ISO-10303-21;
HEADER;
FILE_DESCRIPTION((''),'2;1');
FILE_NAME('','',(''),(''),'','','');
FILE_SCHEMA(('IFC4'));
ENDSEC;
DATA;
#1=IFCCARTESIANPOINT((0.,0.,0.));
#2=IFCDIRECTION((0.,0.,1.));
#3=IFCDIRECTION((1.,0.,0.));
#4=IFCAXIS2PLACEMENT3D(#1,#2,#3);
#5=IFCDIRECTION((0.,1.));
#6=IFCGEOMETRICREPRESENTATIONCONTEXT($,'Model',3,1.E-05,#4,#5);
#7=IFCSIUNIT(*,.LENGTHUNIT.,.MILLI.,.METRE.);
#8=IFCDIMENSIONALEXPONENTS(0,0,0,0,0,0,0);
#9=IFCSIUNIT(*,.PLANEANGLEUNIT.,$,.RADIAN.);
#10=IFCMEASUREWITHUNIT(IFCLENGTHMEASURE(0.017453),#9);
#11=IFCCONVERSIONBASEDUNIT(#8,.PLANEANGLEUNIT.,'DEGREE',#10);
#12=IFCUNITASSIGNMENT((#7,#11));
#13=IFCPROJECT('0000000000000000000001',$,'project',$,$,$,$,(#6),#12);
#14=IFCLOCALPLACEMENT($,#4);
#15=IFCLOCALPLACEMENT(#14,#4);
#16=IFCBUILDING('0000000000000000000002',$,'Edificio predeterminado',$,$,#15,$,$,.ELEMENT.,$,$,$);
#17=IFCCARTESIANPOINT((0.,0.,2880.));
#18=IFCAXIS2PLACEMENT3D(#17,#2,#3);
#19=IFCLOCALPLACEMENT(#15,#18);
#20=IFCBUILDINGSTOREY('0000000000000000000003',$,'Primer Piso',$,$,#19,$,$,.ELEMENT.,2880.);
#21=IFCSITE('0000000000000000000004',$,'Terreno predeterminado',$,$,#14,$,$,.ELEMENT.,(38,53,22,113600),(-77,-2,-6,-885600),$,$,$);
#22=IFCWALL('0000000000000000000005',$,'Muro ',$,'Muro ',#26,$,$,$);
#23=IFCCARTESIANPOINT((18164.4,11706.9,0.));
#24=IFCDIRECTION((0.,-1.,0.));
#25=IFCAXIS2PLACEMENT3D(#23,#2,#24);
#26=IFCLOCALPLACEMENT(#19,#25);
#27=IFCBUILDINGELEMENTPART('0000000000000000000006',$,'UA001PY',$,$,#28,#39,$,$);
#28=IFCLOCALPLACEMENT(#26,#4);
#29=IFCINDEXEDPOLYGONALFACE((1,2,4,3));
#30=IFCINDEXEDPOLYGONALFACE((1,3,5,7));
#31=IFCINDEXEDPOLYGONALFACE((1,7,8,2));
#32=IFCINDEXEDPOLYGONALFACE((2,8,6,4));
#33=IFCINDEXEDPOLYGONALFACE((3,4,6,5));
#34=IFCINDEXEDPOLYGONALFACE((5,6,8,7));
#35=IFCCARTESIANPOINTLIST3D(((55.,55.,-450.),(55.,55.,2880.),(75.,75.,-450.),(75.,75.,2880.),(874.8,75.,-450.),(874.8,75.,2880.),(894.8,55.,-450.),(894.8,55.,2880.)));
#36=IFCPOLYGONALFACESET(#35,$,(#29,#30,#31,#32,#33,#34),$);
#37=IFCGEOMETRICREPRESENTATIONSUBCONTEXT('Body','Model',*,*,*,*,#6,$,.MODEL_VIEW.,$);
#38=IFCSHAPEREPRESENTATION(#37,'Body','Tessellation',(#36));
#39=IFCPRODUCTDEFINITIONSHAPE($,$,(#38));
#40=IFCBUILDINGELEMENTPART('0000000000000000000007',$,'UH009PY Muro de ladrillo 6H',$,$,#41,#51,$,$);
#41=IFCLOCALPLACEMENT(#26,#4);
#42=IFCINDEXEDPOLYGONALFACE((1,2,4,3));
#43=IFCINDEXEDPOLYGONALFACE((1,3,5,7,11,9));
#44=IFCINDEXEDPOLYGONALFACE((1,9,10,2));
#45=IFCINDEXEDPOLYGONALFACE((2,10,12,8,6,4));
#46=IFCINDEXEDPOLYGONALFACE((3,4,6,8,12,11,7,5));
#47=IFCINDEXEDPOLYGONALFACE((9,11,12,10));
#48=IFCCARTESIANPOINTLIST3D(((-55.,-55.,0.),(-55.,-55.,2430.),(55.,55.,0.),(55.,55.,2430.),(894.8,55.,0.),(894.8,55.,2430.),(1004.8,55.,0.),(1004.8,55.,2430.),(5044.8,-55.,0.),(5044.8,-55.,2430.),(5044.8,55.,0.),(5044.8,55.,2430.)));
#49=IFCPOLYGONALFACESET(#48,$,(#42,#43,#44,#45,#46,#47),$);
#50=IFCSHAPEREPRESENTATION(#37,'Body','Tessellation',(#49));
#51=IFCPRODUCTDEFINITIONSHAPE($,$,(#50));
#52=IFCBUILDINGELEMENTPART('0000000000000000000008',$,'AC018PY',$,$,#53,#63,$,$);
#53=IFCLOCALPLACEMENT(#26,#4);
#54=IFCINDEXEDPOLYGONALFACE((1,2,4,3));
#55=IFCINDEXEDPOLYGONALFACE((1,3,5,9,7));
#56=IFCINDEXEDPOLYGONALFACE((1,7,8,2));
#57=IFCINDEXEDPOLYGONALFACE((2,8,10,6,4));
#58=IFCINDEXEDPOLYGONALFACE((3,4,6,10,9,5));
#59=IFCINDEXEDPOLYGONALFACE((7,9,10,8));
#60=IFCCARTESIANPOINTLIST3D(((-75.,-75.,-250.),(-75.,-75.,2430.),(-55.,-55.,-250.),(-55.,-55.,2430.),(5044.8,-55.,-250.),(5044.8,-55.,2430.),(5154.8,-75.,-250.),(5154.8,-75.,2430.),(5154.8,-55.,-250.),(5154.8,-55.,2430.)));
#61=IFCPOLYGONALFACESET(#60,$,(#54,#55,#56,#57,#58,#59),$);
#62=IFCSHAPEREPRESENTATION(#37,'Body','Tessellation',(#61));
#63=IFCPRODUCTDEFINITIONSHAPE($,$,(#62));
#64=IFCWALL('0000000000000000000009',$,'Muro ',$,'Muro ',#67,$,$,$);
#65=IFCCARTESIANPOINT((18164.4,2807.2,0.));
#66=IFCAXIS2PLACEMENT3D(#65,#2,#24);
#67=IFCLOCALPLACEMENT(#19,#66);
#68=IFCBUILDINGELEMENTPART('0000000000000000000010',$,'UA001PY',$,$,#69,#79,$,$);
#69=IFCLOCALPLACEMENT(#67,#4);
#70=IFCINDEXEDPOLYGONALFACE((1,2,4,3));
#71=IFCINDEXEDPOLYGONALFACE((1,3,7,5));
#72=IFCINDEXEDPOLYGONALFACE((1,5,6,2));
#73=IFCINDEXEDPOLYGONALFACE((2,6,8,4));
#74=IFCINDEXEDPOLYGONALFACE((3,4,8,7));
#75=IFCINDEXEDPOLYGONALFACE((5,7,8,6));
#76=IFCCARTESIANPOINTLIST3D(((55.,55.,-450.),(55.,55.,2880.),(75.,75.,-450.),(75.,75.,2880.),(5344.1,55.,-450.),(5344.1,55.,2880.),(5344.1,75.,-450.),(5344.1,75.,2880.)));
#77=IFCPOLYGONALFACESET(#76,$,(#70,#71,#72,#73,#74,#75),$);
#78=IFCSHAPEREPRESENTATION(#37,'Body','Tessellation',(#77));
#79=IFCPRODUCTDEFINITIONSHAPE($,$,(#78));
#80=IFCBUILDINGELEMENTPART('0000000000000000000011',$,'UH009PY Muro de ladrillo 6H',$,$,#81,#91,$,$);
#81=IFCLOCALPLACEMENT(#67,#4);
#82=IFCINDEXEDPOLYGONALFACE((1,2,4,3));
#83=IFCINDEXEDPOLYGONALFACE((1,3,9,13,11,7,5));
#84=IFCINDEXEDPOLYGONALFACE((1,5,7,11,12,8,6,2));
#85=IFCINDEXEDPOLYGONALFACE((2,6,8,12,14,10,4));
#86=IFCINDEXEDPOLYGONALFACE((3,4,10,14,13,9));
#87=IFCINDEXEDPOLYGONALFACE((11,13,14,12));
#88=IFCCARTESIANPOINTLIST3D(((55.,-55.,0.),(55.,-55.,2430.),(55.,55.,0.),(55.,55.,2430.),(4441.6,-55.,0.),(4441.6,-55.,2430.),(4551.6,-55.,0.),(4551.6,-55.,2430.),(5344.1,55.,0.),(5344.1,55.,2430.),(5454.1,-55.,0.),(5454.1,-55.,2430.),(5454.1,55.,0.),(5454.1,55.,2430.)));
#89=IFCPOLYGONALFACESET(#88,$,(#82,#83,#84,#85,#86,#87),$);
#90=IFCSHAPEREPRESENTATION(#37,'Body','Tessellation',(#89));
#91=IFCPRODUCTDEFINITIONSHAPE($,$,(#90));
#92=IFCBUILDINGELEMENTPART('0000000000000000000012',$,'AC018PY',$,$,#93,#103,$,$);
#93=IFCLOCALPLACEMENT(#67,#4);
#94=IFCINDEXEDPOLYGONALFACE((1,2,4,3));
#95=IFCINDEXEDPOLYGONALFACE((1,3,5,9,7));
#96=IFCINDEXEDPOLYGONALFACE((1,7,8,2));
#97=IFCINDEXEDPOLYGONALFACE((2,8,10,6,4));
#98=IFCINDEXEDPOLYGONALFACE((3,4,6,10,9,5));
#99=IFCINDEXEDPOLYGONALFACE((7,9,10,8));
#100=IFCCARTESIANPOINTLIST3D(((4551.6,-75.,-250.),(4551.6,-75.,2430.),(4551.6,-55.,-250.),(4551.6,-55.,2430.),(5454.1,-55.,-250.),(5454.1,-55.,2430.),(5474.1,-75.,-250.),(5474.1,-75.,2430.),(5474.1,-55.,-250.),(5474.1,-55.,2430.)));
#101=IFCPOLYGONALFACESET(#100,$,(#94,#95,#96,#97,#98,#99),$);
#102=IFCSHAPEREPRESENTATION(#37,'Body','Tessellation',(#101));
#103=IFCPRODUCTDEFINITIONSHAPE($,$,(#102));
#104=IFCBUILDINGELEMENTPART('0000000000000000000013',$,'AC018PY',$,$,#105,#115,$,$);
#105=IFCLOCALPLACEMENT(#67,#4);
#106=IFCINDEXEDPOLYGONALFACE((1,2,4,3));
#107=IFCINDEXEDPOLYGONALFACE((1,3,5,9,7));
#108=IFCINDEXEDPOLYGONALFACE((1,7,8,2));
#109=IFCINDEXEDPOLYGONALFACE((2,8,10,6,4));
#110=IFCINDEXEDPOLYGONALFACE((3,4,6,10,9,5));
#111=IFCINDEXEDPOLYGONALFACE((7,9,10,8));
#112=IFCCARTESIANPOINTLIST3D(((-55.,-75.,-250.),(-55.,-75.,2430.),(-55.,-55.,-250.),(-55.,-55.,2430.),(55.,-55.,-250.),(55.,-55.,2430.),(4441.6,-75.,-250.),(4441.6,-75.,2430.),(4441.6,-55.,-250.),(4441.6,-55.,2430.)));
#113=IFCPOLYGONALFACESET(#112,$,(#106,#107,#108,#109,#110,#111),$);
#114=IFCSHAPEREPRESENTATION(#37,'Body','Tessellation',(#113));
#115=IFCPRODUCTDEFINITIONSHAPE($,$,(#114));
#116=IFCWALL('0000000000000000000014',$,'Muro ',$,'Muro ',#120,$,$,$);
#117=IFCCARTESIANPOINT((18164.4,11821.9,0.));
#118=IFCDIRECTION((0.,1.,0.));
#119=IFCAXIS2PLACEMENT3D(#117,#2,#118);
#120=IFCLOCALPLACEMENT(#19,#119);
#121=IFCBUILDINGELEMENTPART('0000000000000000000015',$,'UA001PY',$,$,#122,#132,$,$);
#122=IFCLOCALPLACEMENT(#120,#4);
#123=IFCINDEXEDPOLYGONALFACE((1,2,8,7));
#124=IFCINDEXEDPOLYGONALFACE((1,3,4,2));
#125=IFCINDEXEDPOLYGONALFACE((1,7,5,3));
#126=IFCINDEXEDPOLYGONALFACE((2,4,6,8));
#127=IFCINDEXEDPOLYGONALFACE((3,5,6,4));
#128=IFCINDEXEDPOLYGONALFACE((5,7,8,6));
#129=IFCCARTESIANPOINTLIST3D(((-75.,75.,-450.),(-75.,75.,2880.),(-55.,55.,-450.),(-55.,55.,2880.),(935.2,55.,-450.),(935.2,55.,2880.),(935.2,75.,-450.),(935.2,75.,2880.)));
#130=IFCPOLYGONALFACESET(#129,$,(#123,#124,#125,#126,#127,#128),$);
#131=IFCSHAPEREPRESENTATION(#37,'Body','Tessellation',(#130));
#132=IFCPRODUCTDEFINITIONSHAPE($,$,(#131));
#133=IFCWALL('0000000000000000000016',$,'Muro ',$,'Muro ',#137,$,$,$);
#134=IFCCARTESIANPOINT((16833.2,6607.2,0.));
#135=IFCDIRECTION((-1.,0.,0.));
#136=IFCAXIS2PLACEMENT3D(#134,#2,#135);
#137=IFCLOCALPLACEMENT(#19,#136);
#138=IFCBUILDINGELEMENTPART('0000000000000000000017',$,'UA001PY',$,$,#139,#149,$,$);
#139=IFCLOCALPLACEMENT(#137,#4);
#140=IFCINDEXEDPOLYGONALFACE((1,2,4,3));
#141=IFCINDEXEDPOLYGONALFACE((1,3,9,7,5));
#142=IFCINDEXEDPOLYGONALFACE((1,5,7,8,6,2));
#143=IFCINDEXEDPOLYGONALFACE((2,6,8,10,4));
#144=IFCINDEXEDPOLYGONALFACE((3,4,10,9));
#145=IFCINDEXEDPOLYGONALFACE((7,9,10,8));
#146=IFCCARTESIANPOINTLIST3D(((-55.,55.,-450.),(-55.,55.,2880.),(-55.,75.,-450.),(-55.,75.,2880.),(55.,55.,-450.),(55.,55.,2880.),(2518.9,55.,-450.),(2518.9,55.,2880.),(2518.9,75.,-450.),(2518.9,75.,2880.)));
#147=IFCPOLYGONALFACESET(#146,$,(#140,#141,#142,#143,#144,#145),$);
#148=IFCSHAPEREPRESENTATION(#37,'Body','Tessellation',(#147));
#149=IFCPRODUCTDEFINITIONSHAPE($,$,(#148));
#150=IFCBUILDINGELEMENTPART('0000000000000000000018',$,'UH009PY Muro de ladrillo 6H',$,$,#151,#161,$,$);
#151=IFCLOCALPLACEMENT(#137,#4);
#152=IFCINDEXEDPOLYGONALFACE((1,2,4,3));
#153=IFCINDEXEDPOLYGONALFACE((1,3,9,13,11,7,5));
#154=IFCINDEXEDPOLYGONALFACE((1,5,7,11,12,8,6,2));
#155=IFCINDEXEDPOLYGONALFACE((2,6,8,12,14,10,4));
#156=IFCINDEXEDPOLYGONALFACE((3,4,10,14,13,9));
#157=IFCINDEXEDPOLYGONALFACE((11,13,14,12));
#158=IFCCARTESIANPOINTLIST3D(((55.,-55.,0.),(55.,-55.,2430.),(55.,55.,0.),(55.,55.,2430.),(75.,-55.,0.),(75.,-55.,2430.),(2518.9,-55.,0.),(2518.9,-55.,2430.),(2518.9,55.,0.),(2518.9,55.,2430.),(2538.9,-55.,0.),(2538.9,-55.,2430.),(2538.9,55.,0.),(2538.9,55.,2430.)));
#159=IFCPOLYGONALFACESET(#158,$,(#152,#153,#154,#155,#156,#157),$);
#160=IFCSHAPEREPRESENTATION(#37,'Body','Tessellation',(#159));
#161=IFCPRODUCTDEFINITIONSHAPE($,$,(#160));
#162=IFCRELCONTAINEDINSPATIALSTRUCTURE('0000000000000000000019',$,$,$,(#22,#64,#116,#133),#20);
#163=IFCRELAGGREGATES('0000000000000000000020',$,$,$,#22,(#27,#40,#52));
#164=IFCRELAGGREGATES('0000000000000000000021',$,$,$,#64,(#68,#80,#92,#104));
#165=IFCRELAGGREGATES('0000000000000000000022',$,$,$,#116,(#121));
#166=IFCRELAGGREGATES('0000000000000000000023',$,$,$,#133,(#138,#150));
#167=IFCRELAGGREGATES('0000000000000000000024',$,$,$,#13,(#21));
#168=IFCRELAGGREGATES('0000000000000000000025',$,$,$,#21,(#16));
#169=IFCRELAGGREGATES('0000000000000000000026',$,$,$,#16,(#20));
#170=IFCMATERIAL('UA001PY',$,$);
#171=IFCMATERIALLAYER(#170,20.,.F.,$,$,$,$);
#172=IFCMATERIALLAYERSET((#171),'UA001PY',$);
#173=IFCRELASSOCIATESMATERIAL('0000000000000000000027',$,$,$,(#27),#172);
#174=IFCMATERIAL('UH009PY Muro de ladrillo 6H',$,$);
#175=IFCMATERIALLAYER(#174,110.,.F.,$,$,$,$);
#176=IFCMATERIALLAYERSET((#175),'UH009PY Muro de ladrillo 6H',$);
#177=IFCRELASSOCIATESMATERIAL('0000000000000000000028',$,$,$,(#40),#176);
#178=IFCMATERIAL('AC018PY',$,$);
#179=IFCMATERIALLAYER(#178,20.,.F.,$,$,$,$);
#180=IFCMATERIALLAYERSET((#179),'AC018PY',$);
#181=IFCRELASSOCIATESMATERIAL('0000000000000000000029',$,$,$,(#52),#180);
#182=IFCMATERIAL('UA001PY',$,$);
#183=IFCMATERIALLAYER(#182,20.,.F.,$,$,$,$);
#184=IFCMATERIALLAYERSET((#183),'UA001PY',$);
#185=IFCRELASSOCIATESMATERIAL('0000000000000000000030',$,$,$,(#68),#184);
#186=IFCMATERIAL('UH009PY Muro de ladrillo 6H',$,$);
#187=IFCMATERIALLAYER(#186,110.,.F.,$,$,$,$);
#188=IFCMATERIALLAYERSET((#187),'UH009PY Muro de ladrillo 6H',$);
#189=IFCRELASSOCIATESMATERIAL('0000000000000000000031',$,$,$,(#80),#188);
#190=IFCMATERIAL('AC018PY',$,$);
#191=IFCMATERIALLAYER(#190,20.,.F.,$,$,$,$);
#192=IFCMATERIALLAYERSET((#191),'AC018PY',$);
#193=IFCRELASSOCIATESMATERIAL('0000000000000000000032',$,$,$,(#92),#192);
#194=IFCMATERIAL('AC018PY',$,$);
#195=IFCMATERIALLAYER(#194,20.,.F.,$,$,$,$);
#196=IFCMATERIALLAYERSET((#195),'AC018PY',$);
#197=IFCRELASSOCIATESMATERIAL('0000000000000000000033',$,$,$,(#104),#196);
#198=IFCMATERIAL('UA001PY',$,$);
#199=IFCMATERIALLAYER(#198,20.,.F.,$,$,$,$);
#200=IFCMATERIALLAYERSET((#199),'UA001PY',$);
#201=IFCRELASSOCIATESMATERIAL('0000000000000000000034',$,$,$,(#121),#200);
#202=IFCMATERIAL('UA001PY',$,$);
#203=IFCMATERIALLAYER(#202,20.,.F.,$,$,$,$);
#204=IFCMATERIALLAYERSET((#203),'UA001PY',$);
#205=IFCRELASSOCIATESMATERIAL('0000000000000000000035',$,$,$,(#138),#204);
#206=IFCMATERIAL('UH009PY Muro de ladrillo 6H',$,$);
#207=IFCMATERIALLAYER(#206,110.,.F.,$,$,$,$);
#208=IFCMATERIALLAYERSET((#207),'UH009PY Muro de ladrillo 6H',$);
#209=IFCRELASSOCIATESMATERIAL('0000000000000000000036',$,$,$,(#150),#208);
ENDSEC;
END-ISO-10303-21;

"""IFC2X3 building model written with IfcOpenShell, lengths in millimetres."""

from ifc_helpers import new_model, entity, si_unit, converted_unit, direction, frame, origin_with_axes, place, context, subcontext, project, spatial, polyline, outline, extrude, material, layer, layer_set, layer_usage, element, aggregate, save


model = new_model("IFC2X3")

# Units and contexts
model_context = context("Model", 3, precision=1e-05, world=origin_with_axes(), true_north=direction((0.0, 1.0)))
body_context = subcontext(model_context, "Body", "Model", "MODEL_VIEW")
ifc_project = project(units=[si_unit("LENGTHUNIT", "METRE", prefix="MILLI"), converted_unit("PLANEANGLEUNIT", "DEGREE", entity("IfcLengthMeasure", 0.017453), si_unit("PLANEANGLEUNIT", "RADIAN"), dimensions=[0, 0, 0, 0, 0, 0, 0])], contexts=[model_context])

# Site, building, storey
site_placement = place(None, origin_with_axes())
site = spatial("IfcSite", under=ifc_project, at=site_placement, Name="Terreno predeterminado", CompositionType="ELEMENT", RefLatitude=(38, 53, 22, 113600), RefLongitude=(-77, -2, -6, -885600))
building_placement = place(site_placement, origin_with_axes())
building = spatial("IfcBuilding", under=site, at=building_placement, Name="Edificio predeterminado", CompositionType="ELEMENT")
storey_placement = place(building_placement, frame((0.0, 0.0, 2880.0), z_axis=(0.0, 0.0, 1.0), x_axis=(1.0, 0.0, 0.0)))
storey = spatial("IfcBuildingStorey", under=building, at=storey_placement, Name="Primer Piso", CompositionType="ELEMENT", Elevation=2880.0)

# Walls, building element parts
wall_1_placement = place(storey_placement, frame((18164.4, 11706.9, 0.0), z_axis=(0.0, 0.0, 1.0), x_axis=(0.0, -1.0, 0.0)))
wall_1 = element("IfcWall", 1, at=wall_1_placement, inside=storey, Name="Muro ", ObjectType="Muro ")
ifc_material_1 = material(Name="UA001PY")
ifc_layer_1 = layer(ifc_material_1, 20.0, ventilated=False)
ifc_layer_set_1 = layer_set([ifc_layer_1], Name="UA001PY")
ifc_layer_usage_1 = layer_usage(ifc_layer_set_1, "AXIS2", "NEGATIVE", -75.0)
building_element_part_1_placement = place(wall_1_placement, origin_with_axes())
building_element_part_1 = element("IfcBuildingElementPart", 2, at=building_element_part_1_placement, material=ifc_layer_usage_1, Name="UA001PY", context=body_context, shape_type="SweptSolid", body=[
    extrude(outline(polyline([(874.8, 75.0), (894.8, 55.0), (55.0, 55.0), (75.0, 75.0), (874.8, 75.0)])), frame((0.0, 0.0, -450.0), z_axis=(0.0, 0.0, 1.0), x_axis=(1.0, 0.0, 0.0)), (0.0, 0.0, 1.0), 3330.0),
])
ifc_material_2 = material(Name="UH009PY Muro de ladrillo 6H")
ifc_layer_2 = layer(ifc_material_2, 110.0, ventilated=False)
ifc_layer_set_2 = layer_set([ifc_layer_2], Name="UH009PY Muro de ladrillo 6H")
ifc_layer_usage_2 = layer_usage(ifc_layer_set_2, "AXIS2", "NEGATIVE", -55.0)
building_element_part_2_placement = place(wall_1_placement, origin_with_axes())
building_element_part_2 = element("IfcBuildingElementPart", 3, at=building_element_part_2_placement, material=ifc_layer_usage_2, Name="UH009PY Muro de ladrillo 6H", context=body_context, shape_type="SweptSolid", body=[
    extrude(outline(polyline([(5044.8, 55.0), (5044.8, -55.0), (-55.0, -55.0), (55.0, 55.0), (894.8, 55.0), (1004.8, 55.0), (5044.8, 55.0)])), origin_with_axes(), (0.0, 0.0, 1.0), 2430.0),
])
ifc_material_3 = material(Name="AC018PY")
ifc_layer_3 = layer(ifc_material_3, 20.0, ventilated=False)
ifc_layer_set_3 = layer_set([ifc_layer_3], Name="AC018PY")
ifc_layer_usage_3 = layer_usage(ifc_layer_set_3, "AXIS2", "NEGATIVE", 55.0)
building_element_part_3_placement = place(wall_1_placement, origin_with_axes())
building_element_part_3 = element("IfcBuildingElementPart", 4, at=building_element_part_3_placement, material=ifc_layer_usage_3, Name="AC018PY", context=body_context, shape_type="SweptSolid", body=[
    extrude(outline(polyline([(5154.8, -55.0), (5154.8, -75.0), (-75.0, -75.0), (-55.0, -55.0), (5044.8, -55.0), (5154.8, -55.0)])), frame((0.0, 0.0, -250.0), z_axis=(0.0, 0.0, 1.0), x_axis=(1.0, 0.0, 0.0)), (0.0, 0.0, 1.0), 2680.0),
])
aggregate(wall_1, [building_element_part_1, building_element_part_2, building_element_part_3])
wall_2_placement = place(storey_placement, frame((18164.4, 2807.2, 0.0), z_axis=(0.0, 0.0, 1.0), x_axis=(0.0, -1.0, 0.0)))
wall_2 = element("IfcWall", 5, at=wall_2_placement, inside=storey, Name="Muro ", ObjectType="Muro ")
ifc_material_4 = material(Name="UA001PY")
ifc_layer_4 = layer(ifc_material_4, 20.0, ventilated=False)
ifc_layer_set_4 = layer_set([ifc_layer_4], Name="UA001PY")
ifc_layer_usage_4 = layer_usage(ifc_layer_set_4, "AXIS2", "NEGATIVE", -75.0)
building_element_part_4_placement = place(wall_2_placement, origin_with_axes())
building_element_part_4 = element("IfcBuildingElementPart", 6, at=building_element_part_4_placement, material=ifc_layer_usage_4, Name="UA001PY", context=body_context, shape_type="SweptSolid", body=[
    extrude(outline(polyline([(5344.1, 75.0), (5344.1, 55.0), (55.0, 55.0), (75.0, 75.0), (5344.1, 75.0)])), frame((0.0, 0.0, -450.0), z_axis=(0.0, 0.0, 1.0), x_axis=(1.0, 0.0, 0.0)), (0.0, 0.0, 1.0), 3330.0),
])
ifc_material_5 = material(Name="UH009PY Muro de ladrillo 6H")
ifc_layer_5 = layer(ifc_material_5, 110.0, ventilated=False)
ifc_layer_set_5 = layer_set([ifc_layer_5], Name="UH009PY Muro de ladrillo 6H")
ifc_layer_usage_5 = layer_usage(ifc_layer_set_5, "AXIS2", "NEGATIVE", -55.0)
building_element_part_5_placement = place(wall_2_placement, origin_with_axes())
building_element_part_5 = element("IfcBuildingElementPart", 7, at=building_element_part_5_placement, material=ifc_layer_usage_5, Name="UH009PY Muro de ladrillo 6H", context=body_context, shape_type="SweptSolid", body=[
    extrude(outline(polyline([(5454.1, 55.0), (5454.1, -55.0), (4551.6, -55.0), (4441.6, -55.0), (55.0, -55.0), (55.0, 55.0), (5344.1, 55.0), (5454.1, 55.0)])), origin_with_axes(), (0.0, 0.0, 1.0), 2430.0),
])
ifc_material_6 = material(Name="AC018PY")
ifc_layer_6 = layer(ifc_material_6, 20.0, ventilated=False)
ifc_layer_set_6 = layer_set([ifc_layer_6], Name="AC018PY")
ifc_layer_usage_6 = layer_usage(ifc_layer_set_6, "AXIS2", "NEGATIVE", 55.0)
building_element_part_6_placement = place(wall_2_placement, origin_with_axes())
building_element_part_6 = element("IfcBuildingElementPart", 8, at=building_element_part_6_placement, material=ifc_layer_usage_6, Name="AC018PY", context=body_context, shape_type="SweptSolid", body=[
    extrude(outline(polyline([(5474.1, -55.0), (5474.1, -75.0), (4551.6, -75.0), (4551.6, -55.0), (5454.1, -55.0), (5474.1, -55.0)])), frame((0.0, 0.0, -250.0), z_axis=(0.0, 0.0, 1.0), x_axis=(1.0, 0.0, 0.0)), (0.0, 0.0, 1.0), 2680.0),
])
ifc_material_7 = material(Name="AC018PY")
ifc_layer_7 = layer(ifc_material_7, 20.0, ventilated=False)
ifc_layer_set_7 = layer_set([ifc_layer_7], Name="AC018PY")
ifc_layer_usage_7 = layer_usage(ifc_layer_set_7, "AXIS2", "NEGATIVE", 55.0)
building_element_part_7_placement = place(wall_2_placement, origin_with_axes())
building_element_part_7 = element("IfcBuildingElementPart", 9, at=building_element_part_7_placement, material=ifc_layer_usage_7, Name="AC018PY", context=body_context, shape_type="SweptSolid", body=[
    extrude(outline(polyline([(4441.6, -55.0), (4441.6, -75.0), (-55.0, -75.0), (-55.0, -55.0), (55.0, -55.0), (4441.6, -55.0)])), frame((0.0, 0.0, -250.0), z_axis=(0.0, 0.0, 1.0), x_axis=(1.0, 0.0, 0.0)), (0.0, 0.0, 1.0), 2680.0),
])
aggregate(wall_2, [building_element_part_4, building_element_part_5, building_element_part_6, building_element_part_7])

# Wall, building element part
wall_3_placement = place(storey_placement, frame((18164.4, 11821.9, 0.0), z_axis=(0.0, 0.0, 1.0), x_axis=(0.0, 1.0, 0.0)))
wall_3 = element("IfcWall", 10, at=wall_3_placement, inside=storey, Name="Muro ", ObjectType="Muro ")
ifc_material_8 = material(Name="UA001PY")
ifc_layer_8 = layer(ifc_material_8, 20.0, ventilated=False)
ifc_layer_set_8 = layer_set([ifc_layer_8], Name="UA001PY")
ifc_layer_usage_8 = layer_usage(ifc_layer_set_8, "AXIS2", "NEGATIVE", -75.0)
building_element_part_8_placement = place(wall_3_placement, origin_with_axes())
building_element_part_8 = element("IfcBuildingElementPart", 11, at=building_element_part_8_placement, material=ifc_layer_usage_8, Name="UA001PY", context=body_context, shape_type="SweptSolid", body=[
    extrude(outline(polyline([(935.2, 75.0), (935.2, 55.0), (-55.0, 55.0), (-75.0, 75.0), (935.2, 75.0)])), frame((0.0, 0.0, -450.0), z_axis=(0.0, 0.0, 1.0), x_axis=(1.0, 0.0, 0.0)), (0.0, 0.0, 1.0), 3330.0),
])
aggregate(wall_3, [building_element_part_8])

# Wall, building element parts
wall_4_placement = place(storey_placement, frame((16833.2, 6607.2, 0.0), z_axis=(0.0, 0.0, 1.0), x_axis=(-1.0, 0.0, 0.0)))
wall_4 = element("IfcWall", 12, at=wall_4_placement, inside=storey, Name="Muro ", ObjectType="Muro ")
ifc_material_9 = material(Name="UA001PY")
ifc_layer_9 = layer(ifc_material_9, 20.0, ventilated=False)
ifc_layer_set_9 = layer_set([ifc_layer_9], Name="UA001PY")
ifc_layer_usage_9 = layer_usage(ifc_layer_set_9, "AXIS2", "NEGATIVE", -75.0)
building_element_part_9_placement = place(wall_4_placement, origin_with_axes())
building_element_part_9 = element("IfcBuildingElementPart", 13, at=building_element_part_9_placement, material=ifc_layer_usage_9, Name="UA001PY", context=body_context, shape_type="SweptSolid", body=[
    extrude(outline(polyline([(2518.9, 75.0), (2518.9, 55.0), (55.0, 55.0), (-55.0, 55.0), (-55.0, 75.0), (2518.9, 75.0)])), frame((0.0, 0.0, -450.0), z_axis=(0.0, 0.0, 1.0), x_axis=(1.0, 0.0, 0.0)), (0.0, 0.0, 1.0), 3330.0),
])
ifc_material_10 = material(Name="UH009PY Muro de ladrillo 6H")
ifc_layer_10 = layer(ifc_material_10, 110.0, ventilated=False)
ifc_layer_set_10 = layer_set([ifc_layer_10], Name="UH009PY Muro de ladrillo 6H")
ifc_layer_usage_10 = layer_usage(ifc_layer_set_10, "AXIS2", "NEGATIVE", -55.0)
building_element_part_10_placement = place(wall_4_placement, origin_with_axes())
building_element_part_10 = element("IfcBuildingElementPart", 14, at=building_element_part_10_placement, material=ifc_layer_usage_10, Name="UH009PY Muro de ladrillo 6H", context=body_context, shape_type="SweptSolid", body=[
    extrude(outline(polyline([(2538.9, 55.0), (2538.9, -55.0), (2518.9, -55.0), (75.0, -55.0), (55.0, -55.0), (55.0, 55.0), (2518.9, 55.0), (2538.9, 55.0)])), origin_with_axes(), (0.0, 0.0, 1.0), 2430.0),
])
aggregate(wall_4, [building_element_part_9, building_element_part_10])

save(model, "model.ifc")
